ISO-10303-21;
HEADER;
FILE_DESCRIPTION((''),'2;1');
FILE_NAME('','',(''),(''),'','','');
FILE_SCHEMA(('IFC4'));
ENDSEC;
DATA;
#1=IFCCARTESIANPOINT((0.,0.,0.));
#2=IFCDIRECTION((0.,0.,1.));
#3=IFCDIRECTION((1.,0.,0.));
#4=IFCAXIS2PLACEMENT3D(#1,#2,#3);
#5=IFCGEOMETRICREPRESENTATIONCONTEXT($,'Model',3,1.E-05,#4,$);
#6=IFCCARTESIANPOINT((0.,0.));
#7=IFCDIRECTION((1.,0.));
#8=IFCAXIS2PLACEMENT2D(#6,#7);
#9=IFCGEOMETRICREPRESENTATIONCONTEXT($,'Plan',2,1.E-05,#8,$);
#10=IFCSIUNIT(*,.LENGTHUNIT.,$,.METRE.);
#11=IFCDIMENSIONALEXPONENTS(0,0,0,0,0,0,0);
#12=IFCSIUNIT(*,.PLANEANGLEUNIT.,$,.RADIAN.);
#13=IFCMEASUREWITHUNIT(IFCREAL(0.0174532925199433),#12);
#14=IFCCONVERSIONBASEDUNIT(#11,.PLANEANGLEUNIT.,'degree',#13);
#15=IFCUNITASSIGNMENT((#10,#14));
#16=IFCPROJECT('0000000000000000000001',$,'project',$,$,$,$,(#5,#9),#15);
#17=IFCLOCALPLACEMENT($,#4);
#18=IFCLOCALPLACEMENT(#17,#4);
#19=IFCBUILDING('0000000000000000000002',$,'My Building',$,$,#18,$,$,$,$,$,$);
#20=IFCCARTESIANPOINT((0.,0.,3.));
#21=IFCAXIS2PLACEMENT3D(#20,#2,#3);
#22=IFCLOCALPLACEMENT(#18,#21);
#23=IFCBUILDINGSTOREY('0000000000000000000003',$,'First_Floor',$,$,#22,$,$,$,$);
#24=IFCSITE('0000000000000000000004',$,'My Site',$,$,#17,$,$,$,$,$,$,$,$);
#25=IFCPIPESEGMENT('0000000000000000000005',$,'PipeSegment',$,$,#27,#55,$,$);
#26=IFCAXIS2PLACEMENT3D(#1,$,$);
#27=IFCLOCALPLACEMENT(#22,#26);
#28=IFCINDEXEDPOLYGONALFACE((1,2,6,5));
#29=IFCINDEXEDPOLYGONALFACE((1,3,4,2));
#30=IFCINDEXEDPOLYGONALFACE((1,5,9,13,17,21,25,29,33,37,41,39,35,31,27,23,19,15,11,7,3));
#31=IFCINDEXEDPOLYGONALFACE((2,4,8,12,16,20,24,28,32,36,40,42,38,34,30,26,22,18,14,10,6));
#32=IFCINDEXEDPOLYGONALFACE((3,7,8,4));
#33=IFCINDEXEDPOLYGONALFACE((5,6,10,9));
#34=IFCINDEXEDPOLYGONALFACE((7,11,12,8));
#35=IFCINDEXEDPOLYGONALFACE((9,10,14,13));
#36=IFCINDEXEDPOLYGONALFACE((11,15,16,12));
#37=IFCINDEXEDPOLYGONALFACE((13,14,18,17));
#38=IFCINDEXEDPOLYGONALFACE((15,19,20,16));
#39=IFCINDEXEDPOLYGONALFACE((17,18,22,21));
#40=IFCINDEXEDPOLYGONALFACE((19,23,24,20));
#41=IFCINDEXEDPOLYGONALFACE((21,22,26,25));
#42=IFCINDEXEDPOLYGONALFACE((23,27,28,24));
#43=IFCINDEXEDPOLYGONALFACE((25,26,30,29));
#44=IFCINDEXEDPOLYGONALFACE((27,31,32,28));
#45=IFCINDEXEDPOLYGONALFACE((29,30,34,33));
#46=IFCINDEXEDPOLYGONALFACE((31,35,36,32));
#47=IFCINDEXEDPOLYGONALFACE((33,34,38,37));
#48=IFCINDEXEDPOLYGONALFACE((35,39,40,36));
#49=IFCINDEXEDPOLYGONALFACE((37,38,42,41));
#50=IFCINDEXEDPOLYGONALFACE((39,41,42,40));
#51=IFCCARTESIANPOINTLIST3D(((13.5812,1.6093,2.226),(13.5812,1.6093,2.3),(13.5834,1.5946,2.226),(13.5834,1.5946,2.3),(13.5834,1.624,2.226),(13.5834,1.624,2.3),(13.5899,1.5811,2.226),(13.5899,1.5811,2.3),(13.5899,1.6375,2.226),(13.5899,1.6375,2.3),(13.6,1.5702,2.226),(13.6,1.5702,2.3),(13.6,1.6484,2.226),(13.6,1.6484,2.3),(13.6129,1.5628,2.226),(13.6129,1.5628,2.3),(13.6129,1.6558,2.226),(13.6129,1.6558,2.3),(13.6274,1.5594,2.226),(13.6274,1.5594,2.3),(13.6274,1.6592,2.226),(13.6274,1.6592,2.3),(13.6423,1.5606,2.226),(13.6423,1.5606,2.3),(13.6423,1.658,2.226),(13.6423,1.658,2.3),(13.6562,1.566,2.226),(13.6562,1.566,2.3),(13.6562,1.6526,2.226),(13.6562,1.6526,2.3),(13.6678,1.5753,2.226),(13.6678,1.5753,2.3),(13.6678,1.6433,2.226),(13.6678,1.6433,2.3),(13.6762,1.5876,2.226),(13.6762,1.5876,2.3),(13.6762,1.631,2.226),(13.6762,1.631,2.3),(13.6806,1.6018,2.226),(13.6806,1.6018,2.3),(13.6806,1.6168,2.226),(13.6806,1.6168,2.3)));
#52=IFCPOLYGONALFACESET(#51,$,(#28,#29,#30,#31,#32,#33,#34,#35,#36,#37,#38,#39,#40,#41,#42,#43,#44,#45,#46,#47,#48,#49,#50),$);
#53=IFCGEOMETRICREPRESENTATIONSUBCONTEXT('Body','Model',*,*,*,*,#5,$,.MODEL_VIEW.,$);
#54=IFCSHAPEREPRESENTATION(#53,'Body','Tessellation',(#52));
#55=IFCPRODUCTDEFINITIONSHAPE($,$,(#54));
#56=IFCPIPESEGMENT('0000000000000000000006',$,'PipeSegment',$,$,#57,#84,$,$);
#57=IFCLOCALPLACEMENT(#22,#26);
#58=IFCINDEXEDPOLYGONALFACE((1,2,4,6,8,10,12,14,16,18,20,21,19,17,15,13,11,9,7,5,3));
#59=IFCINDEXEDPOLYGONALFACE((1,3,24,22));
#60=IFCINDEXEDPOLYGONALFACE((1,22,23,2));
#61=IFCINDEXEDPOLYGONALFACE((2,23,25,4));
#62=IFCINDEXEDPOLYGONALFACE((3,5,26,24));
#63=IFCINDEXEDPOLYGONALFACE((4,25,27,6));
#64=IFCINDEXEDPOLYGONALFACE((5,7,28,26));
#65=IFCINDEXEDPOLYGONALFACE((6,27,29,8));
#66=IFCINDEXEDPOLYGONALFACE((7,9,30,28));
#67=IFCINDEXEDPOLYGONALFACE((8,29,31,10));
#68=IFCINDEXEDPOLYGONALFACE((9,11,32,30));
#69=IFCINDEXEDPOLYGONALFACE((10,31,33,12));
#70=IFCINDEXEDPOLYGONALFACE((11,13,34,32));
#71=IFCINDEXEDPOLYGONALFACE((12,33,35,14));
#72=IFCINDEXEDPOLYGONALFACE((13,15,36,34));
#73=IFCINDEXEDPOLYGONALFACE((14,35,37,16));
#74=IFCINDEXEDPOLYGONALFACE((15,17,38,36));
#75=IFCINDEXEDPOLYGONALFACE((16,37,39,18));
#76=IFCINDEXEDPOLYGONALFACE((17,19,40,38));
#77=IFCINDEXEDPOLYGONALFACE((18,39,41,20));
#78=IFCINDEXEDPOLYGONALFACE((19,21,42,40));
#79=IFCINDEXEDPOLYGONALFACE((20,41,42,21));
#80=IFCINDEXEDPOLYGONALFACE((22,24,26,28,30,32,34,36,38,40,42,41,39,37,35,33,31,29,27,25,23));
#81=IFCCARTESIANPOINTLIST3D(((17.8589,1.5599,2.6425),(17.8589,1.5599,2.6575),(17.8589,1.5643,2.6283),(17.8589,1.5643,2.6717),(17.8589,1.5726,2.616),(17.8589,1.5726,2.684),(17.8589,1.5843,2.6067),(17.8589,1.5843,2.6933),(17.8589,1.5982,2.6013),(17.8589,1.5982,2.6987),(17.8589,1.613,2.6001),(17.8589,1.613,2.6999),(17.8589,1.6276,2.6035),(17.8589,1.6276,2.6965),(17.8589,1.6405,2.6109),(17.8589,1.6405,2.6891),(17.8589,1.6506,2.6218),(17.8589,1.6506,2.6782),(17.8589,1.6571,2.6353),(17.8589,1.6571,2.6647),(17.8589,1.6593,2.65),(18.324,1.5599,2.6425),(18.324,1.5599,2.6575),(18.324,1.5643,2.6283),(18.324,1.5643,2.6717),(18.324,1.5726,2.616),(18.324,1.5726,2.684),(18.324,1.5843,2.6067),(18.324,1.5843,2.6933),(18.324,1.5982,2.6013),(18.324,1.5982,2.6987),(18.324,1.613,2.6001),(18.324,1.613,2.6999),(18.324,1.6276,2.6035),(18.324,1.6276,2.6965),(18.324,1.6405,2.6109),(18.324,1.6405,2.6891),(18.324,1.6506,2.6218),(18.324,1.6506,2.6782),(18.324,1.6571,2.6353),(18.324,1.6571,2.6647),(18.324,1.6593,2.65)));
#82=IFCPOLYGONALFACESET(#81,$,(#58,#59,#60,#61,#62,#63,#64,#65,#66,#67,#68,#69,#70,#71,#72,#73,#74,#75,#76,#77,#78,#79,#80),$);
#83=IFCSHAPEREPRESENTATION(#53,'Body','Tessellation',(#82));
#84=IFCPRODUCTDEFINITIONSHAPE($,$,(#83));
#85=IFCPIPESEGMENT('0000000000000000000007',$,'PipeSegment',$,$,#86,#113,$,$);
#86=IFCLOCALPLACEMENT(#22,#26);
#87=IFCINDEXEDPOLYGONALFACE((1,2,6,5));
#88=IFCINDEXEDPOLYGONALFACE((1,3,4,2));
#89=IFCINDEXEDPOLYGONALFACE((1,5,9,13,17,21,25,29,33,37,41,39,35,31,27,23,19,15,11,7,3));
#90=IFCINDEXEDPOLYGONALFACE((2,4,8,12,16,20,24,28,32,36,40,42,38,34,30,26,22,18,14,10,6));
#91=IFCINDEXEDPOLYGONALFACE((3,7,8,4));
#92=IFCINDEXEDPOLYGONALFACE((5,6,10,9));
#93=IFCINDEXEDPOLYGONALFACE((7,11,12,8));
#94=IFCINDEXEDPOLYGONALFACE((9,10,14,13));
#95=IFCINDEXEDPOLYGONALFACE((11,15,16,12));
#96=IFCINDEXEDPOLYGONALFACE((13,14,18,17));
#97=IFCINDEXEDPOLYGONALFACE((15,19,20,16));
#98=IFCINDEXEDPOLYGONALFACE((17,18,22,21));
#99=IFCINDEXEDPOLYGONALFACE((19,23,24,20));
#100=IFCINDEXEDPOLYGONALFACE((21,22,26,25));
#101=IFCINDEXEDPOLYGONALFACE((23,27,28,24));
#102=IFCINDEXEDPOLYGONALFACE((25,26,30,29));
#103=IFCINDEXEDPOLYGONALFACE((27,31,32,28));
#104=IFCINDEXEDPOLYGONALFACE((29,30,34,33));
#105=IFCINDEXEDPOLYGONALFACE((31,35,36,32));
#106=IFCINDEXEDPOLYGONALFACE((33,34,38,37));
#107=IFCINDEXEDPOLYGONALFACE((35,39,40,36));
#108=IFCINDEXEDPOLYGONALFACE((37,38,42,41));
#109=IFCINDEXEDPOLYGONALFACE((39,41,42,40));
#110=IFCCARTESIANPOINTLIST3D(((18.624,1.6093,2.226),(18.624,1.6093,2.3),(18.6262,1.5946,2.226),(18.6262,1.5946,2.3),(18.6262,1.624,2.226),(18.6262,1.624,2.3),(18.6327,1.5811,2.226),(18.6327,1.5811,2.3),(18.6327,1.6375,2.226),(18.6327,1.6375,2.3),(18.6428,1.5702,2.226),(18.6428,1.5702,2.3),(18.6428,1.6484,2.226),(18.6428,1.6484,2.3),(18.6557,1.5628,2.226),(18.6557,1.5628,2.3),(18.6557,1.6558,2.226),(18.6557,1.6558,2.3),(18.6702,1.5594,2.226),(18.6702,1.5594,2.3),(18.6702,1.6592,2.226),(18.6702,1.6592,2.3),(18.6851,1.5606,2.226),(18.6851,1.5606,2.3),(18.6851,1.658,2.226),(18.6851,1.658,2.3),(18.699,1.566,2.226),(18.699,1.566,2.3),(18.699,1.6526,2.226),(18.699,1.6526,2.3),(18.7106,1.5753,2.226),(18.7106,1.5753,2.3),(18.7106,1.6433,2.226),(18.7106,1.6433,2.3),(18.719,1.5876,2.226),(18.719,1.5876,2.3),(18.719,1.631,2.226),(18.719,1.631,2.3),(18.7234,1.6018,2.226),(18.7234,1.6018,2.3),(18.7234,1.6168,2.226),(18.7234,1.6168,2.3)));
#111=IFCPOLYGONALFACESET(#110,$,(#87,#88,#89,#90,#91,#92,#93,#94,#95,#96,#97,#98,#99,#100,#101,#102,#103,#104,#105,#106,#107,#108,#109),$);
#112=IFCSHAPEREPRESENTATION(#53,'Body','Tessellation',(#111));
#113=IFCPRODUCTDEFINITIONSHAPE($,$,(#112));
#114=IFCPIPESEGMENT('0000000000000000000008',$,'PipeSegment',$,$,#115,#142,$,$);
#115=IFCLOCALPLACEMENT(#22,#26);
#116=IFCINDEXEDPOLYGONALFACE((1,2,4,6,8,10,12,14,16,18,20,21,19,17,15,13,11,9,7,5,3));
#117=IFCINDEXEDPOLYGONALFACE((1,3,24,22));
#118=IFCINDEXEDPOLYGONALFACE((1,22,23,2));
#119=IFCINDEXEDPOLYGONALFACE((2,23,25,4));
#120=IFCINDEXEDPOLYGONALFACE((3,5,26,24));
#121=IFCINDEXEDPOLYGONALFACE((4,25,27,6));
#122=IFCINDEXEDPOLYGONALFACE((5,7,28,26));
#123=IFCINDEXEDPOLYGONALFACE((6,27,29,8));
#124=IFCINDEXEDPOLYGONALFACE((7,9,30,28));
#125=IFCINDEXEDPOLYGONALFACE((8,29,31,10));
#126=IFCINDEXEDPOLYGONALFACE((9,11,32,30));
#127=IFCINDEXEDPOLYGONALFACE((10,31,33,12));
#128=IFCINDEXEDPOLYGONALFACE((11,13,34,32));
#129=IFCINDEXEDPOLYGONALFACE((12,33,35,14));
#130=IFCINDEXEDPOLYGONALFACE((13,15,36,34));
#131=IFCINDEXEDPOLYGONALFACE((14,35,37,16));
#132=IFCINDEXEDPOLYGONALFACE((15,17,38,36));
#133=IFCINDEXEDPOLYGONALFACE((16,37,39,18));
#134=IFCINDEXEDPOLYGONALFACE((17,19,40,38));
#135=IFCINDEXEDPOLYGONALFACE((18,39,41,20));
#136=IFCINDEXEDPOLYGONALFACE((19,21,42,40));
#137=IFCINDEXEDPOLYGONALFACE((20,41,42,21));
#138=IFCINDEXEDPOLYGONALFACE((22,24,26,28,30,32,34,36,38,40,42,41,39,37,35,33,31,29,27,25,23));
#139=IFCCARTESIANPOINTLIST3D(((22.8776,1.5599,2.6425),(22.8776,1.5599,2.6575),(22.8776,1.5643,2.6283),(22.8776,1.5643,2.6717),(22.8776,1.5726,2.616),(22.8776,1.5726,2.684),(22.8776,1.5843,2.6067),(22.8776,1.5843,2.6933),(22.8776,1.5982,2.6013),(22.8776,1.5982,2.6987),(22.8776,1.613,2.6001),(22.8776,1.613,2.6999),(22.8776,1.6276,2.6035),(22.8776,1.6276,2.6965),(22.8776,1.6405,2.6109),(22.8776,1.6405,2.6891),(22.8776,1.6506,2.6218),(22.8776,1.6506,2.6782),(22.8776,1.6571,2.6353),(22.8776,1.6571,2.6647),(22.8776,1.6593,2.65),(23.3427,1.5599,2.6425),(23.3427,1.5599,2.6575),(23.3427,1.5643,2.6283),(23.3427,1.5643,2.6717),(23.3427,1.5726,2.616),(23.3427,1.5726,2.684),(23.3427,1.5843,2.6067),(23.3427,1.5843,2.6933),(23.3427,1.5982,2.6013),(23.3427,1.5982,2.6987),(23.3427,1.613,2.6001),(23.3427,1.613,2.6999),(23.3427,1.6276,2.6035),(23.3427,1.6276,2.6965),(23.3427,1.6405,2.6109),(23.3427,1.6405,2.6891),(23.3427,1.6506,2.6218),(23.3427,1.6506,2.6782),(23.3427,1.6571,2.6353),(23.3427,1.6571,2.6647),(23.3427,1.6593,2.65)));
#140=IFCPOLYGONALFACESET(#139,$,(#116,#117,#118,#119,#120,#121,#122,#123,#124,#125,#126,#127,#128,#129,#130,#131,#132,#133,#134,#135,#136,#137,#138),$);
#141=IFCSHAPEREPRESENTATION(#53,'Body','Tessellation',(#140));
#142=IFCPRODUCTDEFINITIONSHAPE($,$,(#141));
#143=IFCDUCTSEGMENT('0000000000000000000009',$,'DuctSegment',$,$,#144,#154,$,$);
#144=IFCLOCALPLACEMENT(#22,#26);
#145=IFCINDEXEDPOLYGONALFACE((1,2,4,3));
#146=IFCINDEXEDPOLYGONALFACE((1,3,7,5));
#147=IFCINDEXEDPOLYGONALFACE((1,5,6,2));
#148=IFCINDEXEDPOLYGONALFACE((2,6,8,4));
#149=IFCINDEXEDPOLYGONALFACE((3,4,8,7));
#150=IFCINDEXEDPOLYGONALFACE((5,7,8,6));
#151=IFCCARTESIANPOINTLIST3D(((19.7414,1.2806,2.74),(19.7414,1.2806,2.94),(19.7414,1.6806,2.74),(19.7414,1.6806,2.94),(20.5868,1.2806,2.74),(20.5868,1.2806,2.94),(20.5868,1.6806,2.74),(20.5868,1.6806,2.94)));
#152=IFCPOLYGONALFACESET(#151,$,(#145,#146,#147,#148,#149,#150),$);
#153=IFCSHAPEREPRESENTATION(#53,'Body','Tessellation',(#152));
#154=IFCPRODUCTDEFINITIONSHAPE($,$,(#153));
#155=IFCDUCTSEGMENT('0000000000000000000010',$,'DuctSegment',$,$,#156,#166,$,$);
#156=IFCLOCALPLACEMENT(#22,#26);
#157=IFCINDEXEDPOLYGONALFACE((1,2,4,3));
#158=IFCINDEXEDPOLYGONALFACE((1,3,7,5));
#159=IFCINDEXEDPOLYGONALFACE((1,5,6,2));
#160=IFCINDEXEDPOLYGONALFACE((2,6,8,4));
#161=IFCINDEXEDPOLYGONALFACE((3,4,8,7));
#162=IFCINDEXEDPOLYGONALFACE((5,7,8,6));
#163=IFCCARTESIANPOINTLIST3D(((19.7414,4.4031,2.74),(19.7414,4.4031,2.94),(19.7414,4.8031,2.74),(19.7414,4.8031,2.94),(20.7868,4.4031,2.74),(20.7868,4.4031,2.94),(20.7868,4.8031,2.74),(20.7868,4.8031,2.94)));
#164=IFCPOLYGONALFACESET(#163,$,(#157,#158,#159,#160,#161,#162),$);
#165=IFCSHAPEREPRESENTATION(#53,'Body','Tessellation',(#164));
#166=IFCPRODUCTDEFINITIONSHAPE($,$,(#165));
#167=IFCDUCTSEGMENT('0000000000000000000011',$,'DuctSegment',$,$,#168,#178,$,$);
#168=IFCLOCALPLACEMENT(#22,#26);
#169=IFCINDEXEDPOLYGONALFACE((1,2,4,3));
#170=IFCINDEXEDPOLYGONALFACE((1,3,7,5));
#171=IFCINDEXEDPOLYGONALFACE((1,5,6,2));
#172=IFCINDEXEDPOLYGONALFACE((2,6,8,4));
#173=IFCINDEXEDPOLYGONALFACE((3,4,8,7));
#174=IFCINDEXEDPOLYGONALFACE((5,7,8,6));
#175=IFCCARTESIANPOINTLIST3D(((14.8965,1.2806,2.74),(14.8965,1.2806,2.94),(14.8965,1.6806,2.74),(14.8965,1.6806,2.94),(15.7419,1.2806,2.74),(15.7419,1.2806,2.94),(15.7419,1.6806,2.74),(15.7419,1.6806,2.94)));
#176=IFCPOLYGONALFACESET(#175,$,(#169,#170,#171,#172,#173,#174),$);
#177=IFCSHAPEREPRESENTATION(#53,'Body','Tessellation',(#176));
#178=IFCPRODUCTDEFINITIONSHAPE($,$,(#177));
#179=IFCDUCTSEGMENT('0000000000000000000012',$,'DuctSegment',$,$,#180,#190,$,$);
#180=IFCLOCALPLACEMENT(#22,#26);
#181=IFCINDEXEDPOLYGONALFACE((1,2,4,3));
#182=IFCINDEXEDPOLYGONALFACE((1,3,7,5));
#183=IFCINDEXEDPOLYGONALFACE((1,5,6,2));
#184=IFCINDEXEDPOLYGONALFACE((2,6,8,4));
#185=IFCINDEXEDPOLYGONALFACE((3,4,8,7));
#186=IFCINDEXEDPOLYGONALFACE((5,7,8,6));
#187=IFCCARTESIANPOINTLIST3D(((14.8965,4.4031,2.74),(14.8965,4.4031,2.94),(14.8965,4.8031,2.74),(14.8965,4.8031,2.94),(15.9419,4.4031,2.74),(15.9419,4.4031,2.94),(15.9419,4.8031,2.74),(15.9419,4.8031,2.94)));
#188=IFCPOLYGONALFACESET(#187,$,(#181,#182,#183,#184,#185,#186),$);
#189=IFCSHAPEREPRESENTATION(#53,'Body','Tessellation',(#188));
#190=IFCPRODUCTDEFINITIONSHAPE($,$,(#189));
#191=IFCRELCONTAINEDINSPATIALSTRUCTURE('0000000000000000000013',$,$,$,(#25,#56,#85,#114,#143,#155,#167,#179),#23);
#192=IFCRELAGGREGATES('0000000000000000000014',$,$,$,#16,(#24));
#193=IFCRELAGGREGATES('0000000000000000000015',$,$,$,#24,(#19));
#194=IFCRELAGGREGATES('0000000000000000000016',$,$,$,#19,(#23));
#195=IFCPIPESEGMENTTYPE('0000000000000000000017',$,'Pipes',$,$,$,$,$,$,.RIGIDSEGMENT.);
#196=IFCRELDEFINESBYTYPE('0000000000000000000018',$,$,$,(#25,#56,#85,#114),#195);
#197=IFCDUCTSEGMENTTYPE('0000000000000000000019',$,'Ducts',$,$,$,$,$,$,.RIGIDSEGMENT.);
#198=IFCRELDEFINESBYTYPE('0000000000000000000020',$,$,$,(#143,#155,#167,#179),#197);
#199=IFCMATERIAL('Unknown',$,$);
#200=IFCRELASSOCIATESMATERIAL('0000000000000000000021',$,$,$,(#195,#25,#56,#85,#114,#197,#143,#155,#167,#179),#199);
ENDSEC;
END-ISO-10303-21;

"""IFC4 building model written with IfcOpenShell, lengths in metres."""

from ifc_helpers import new_model, entity, si_unit, converted_unit, frame, origin_with_axes, origin_2d_with_axis, place, context, subcontext, project, spatial, rectangle, circle, extrude, material, material_profile, profile_set, profile_usage, type_object, element, save


model = new_model("IFC4")

# Units and contexts
model_context = context("Model", 3, precision=1e-05, world=origin_with_axes())
plan_context = context("Plan", 2, precision=1e-05, world=origin_2d_with_axis())
body_context = subcontext(model_context, "Body", "Model", "MODEL_VIEW")
ifc_project = project(units=[si_unit("LENGTHUNIT", "METRE"), converted_unit("PLANEANGLEUNIT", "degree", entity("IfcReal", 0.0174532925199433), si_unit("PLANEANGLEUNIT", "RADIAN"), dimensions=[0, 0, 0, 0, 0, 0, 0])], contexts=[model_context, plan_context])

# Site, building, storey
site_placement = place(None, origin_with_axes())
site = spatial("IfcSite", under=ifc_project, at=site_placement, Name="My Site")
building_placement = place(site_placement, origin_with_axes())
building = spatial("IfcBuilding", under=site, at=building_placement, Name="My Building")
storey_placement = place(building_placement, frame((0.0, 0.0, 3.0), z_axis=(0.0, 0.0, 1.0), x_axis=(1.0, 0.0, 0.0)))
storey = spatial("IfcBuildingStorey", under=building, at=storey_placement, Name="First_Floor")

# Shared definitions
ifc_material = material(Name="Unknown")

# Pipe segments
ifc_material_profile_1 = material_profile(ifc_material, circle(Radius=0.05))
ifc_profile_set_1 = profile_set([ifc_material_profile_1])
pipe_segment_type = type_object("IfcPipeSegmentType", Name="Pipes", PredefinedType="RIGIDSEGMENT", material=ifc_profile_set_1)
ifc_profile_usage_1 = profile_usage(ifc_profile_set_1, cardinal=5)
pipe_segment_1_placement = place(storey_placement, frame((13.6312, 1.6093, 2.3), z_axis=(0.0, 0.0, -1.0), x_axis=(-1.0, 0.0, 0.0)))
element("IfcPipeSegment", 1, at=pipe_segment_1_placement, inside=storey, type_object=pipe_segment_type, material=ifc_profile_usage_1, Name="PipeSegment", context=body_context, shape_type="SweptSolid", body=[
    extrude(circle(Radius=0.05), origin_with_axes(), (0.0, 0.0, 1.0), 0.074),
])
ifc_profile_usage_2 = profile_usage(ifc_profile_set_1, cardinal=5)
pipe_segment_2_placement = place(storey_placement, frame((17.8589, 1.6093, 2.65), z_axis=(1.0, 0.0, 0.0), x_axis=(0.0, 1.0, 0.0)))
element("IfcPipeSegment", 2, at=pipe_segment_2_placement, inside=storey, type_object=pipe_segment_type, material=ifc_profile_usage_2, Name="PipeSegment", context=body_context, shape_type="SweptSolid", body=[
    extrude(circle(Radius=0.05), origin_with_axes(), (0.0, 0.0, 1.0), 0.4651),
])
ifc_profile_usage_3 = profile_usage(ifc_profile_set_1, cardinal=5)
pipe_segment_3_placement = place(storey_placement, frame((18.674, 1.6093, 2.3), z_axis=(0.0, 0.0, -1.0), x_axis=(-1.0, 0.0, 0.0)))
element("IfcPipeSegment", 3, at=pipe_segment_3_placement, inside=storey, type_object=pipe_segment_type, material=ifc_profile_usage_3, Name="PipeSegment", context=body_context, shape_type="SweptSolid", body=[
    extrude(circle(Radius=0.05), origin_with_axes(), (0.0, 0.0, 1.0), 0.074),
])
ifc_profile_usage_4 = profile_usage(ifc_profile_set_1, cardinal=5)
pipe_segment_4_placement = place(storey_placement, frame((22.8776, 1.6093, 2.65), z_axis=(1.0, 0.0, 0.0), x_axis=(0.0, 1.0, 0.0)))
element("IfcPipeSegment", 4, at=pipe_segment_4_placement, inside=storey, type_object=pipe_segment_type, material=ifc_profile_usage_4, Name="PipeSegment", context=body_context, shape_type="SweptSolid", body=[
    extrude(circle(Radius=0.05), origin_with_axes(), (0.0, 0.0, 1.0), 0.4651),
])

# Duct segments
ifc_material_profile_2 = material_profile(ifc_material, rectangle(XDim=0.4, YDim=0.2))
ifc_profile_set_2 = profile_set([ifc_material_profile_2])
ifc_profile_usage_5 = profile_usage(ifc_profile_set_2, cardinal=5)
duct_segment_type = type_object("IfcDuctSegmentType", Name="Ducts", PredefinedType="RIGIDSEGMENT", material=ifc_profile_set_2)
duct_segment_1_placement = place(storey_placement, frame((20.5868, 1.4806, 2.84), z_axis=(-1.0, 0.0, -0.000001), x_axis=(0.0, -1.0, 0.0)))
element("IfcDuctSegment", 5, at=duct_segment_1_placement, inside=storey, type_object=duct_segment_type, material=ifc_profile_usage_5, Name="DuctSegment", context=body_context, shape_type="SweptSolid", body=[
    extrude(rectangle(XDim=0.4, YDim=0.2), origin_with_axes(), (0.0, 0.0, 1.0), 0.8454),
])
ifc_profile_usage_6 = profile_usage(ifc_profile_set_2, cardinal=5)
duct_segment_2_placement = place(storey_placement, frame((20.7868, 4.6031, 2.84), z_axis=(-1.0, 0.0, 0.0), x_axis=(0.0, -1.0, 0.0)))
element("IfcDuctSegment", 6, at=duct_segment_2_placement, inside=storey, type_object=duct_segment_type, material=ifc_profile_usage_6, Name="DuctSegment", context=body_context, shape_type="SweptSolid", body=[
    extrude(rectangle(XDim=0.4, YDim=0.2), origin_with_axes(), (0.0, 0.0, 1.0), 1.0454),
])
ifc_profile_usage_7 = profile_usage(ifc_profile_set_2, cardinal=5)
duct_segment_3_placement = place(storey_placement, frame((15.7419, 1.4806, 2.84), z_axis=(-1.0, 0.0, -0.000001), x_axis=(0.0, -1.0, 0.0)))
element("IfcDuctSegment", 7, at=duct_segment_3_placement, inside=storey, type_object=duct_segment_type, material=ifc_profile_usage_7, Name="DuctSegment", context=body_context, shape_type="SweptSolid", body=[
    extrude(rectangle(XDim=0.4, YDim=0.2), origin_with_axes(), (0.0, 0.0, 1.0), 0.8454),
])
ifc_profile_usage_8 = profile_usage(ifc_profile_set_2, cardinal=5)
duct_segment_4_placement = place(storey_placement, frame((15.9419, 4.6031, 2.84), z_axis=(-1.0, 0.0, 0.0), x_axis=(0.0, -1.0, 0.0)))
element("IfcDuctSegment", 8, at=duct_segment_4_placement, inside=storey, type_object=duct_segment_type, material=ifc_profile_usage_8, Name="DuctSegment", context=body_context, shape_type="SweptSolid", body=[
    extrude(rectangle(XDim=0.4, YDim=0.2), origin_with_axes(), (0.0, 0.0, 1.0), 1.0454),
])

save(model, "model.ifc")
